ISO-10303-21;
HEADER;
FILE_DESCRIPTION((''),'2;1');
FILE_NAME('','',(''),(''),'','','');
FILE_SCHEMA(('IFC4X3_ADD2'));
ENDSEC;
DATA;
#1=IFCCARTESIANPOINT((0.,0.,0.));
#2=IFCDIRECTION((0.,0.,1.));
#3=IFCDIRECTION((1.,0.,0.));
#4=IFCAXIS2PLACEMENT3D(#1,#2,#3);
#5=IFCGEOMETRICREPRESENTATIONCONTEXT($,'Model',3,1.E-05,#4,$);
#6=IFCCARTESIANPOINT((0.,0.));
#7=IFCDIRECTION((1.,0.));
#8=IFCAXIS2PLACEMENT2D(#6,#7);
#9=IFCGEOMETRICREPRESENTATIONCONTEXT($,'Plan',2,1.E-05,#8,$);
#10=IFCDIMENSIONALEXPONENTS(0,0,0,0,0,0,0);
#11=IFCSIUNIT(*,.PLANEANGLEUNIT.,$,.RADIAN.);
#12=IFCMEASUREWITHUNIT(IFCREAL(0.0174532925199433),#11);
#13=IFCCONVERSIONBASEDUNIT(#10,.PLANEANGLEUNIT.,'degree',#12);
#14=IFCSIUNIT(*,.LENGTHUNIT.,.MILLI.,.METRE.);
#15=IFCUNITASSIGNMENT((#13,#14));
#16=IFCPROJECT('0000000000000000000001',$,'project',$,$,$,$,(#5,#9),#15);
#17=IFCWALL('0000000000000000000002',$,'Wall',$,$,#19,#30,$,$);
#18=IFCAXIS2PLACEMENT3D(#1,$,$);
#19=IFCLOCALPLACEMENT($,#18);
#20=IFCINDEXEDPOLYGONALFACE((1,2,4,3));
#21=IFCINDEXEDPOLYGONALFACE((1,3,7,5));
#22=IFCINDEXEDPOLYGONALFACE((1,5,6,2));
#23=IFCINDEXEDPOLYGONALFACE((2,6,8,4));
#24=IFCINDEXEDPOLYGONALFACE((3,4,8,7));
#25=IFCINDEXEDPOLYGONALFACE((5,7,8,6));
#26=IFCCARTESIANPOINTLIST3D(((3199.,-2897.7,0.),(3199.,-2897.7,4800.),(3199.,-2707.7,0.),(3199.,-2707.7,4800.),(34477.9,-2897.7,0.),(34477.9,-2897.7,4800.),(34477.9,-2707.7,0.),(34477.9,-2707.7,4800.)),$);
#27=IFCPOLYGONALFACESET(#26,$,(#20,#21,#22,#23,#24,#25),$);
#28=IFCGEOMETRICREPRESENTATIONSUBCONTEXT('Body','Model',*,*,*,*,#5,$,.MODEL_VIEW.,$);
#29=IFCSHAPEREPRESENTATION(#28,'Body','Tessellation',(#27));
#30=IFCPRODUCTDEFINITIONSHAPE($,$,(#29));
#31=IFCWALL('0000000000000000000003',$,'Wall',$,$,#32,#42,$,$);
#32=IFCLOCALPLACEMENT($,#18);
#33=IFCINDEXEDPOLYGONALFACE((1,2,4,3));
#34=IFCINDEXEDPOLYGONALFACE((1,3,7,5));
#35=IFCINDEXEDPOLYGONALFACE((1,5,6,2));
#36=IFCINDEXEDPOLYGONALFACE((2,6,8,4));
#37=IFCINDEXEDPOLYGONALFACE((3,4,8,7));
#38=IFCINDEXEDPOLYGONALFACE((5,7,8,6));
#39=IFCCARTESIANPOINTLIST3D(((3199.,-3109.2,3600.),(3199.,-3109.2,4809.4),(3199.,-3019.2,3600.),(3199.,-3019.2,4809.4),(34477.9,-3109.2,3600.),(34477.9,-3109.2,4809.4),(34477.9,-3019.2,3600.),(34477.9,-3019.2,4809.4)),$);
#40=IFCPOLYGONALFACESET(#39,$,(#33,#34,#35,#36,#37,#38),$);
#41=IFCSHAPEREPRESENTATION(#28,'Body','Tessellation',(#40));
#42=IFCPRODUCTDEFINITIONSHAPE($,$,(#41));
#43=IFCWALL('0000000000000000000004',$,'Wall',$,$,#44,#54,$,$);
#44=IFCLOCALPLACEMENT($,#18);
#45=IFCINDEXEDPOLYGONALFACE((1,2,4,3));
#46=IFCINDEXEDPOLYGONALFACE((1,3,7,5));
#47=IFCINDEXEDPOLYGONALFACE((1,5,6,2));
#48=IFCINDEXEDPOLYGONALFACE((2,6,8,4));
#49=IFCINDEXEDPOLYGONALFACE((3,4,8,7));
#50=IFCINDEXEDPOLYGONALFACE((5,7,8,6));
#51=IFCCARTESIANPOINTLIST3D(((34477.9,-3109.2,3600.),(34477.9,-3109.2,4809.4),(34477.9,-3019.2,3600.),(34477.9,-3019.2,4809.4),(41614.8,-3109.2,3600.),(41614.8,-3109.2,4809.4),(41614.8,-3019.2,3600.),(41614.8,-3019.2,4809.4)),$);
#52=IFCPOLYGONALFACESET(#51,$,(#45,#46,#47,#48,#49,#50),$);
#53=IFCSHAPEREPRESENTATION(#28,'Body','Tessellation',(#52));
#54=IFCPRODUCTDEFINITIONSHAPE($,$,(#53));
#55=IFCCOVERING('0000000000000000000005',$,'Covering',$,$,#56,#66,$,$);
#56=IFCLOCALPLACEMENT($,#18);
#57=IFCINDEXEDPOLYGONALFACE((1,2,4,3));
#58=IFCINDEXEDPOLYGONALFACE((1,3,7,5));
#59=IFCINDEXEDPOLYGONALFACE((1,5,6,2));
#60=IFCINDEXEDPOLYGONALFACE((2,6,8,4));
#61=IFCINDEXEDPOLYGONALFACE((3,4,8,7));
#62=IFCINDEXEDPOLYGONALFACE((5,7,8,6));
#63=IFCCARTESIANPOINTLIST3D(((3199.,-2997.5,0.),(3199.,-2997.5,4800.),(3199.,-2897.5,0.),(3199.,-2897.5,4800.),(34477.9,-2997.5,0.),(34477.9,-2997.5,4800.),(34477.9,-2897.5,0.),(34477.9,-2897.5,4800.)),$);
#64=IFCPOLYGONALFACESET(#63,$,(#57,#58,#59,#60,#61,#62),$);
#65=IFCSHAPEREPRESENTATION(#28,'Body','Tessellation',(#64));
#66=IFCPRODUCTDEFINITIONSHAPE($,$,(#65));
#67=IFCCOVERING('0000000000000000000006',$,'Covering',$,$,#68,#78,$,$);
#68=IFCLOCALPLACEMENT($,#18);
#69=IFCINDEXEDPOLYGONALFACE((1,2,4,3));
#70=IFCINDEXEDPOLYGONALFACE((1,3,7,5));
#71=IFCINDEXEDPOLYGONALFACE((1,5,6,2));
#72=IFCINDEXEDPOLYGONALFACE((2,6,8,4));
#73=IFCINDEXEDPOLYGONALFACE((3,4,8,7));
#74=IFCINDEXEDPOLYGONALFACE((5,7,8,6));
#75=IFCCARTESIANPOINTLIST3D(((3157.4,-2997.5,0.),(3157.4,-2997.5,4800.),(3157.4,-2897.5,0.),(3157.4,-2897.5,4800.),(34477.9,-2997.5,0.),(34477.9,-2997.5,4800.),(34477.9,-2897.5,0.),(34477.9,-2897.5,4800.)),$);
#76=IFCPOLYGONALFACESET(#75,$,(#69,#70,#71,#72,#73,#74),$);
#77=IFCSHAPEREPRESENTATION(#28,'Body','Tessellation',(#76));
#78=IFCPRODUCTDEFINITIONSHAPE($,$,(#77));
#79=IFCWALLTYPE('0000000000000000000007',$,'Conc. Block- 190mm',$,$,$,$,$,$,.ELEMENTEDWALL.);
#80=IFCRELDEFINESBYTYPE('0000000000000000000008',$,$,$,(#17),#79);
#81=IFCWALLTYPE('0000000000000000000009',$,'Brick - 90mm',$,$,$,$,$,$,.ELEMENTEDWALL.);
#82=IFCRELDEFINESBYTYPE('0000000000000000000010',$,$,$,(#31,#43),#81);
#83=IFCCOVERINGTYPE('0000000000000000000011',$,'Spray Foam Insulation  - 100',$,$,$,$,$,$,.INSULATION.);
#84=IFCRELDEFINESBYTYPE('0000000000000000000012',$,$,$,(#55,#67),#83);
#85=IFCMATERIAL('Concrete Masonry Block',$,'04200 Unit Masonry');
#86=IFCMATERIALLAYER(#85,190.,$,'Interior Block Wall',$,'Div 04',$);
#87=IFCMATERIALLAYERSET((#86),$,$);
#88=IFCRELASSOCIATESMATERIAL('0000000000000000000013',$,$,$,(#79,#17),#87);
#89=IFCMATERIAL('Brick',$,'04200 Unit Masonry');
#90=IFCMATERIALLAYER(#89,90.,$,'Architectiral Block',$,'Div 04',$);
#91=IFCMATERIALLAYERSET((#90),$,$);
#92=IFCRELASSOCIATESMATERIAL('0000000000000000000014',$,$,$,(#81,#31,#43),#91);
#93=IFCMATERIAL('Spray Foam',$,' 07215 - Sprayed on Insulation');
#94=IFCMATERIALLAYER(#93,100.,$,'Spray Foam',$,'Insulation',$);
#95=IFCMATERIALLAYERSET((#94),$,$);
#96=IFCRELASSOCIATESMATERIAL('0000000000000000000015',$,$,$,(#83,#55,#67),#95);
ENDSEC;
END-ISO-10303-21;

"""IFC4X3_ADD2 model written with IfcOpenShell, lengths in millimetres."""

from ifc_helpers import new_model, entity, si_unit, converted_unit, frame, origin_with_axes, origin_2d_with_axis, place, context, subcontext, project, indexed_curve, outline, extrude, material, layer, layer_set, layer_usage, type_object, element, save


model = new_model("IFC4X3_ADD2")

# Units and contexts
model_context = context("Model", 3, precision=1e-05, world=origin_with_axes())
plan_context = context("Plan", 2, precision=1e-05, world=origin_2d_with_axis())
body_context = subcontext(model_context, "Body", "Model", "MODEL_VIEW")
ifc_project = project(units=[converted_unit("PLANEANGLEUNIT", "degree", entity("IfcReal", 0.0174532925199433), si_unit("PLANEANGLEUNIT", "RADIAN"), dimensions=[0, 0, 0, 0, 0, 0, 0]), si_unit("LENGTHUNIT", "METRE", prefix="MILLI")], contexts=[model_context, plan_context])

# Walls
ifc_material_1 = material(Name="Concrete Masonry Block", Category="04200 Unit Masonry")
ifc_layer_1 = layer(ifc_material_1, 190.0, Name="Interior Block Wall", Category="Div 04")
ifc_layer_set_1 = layer_set([ifc_layer_1])
ifc_layer_usage_1 = layer_usage(ifc_layer_set_1, "AXIS2", "POSITIVE", 0.0)
wall_type_1 = type_object("IfcWallType", Name="Conc. Block- 190mm", PredefinedType="ELEMENTEDWALL", material=ifc_layer_set_1)
wall_1_placement = place(None, frame((34477.9, -2707.7, 0.0), z_axis=(0.0, 0.0, 1.0), x_axis=(-1.0, 0.0, 0.0)))
element("IfcWall", 1, at=wall_1_placement, type_object=wall_type_1, material=ifc_layer_usage_1, Name="Wall", context=body_context, shape_type="SweptSolid", body=[
    extrude(outline(indexed_curve([(0.0, 0.0), (0.0, 190.0), (31278.9, 190.0), (31278.9, 0.0), (0.0, 0.0)], self_intersect=False)), origin_with_axes(), (0.0, 0.0, 1.0), 4800.0),
])
ifc_material_2 = material(Name="Brick", Category="04200 Unit Masonry")
ifc_layer_2 = layer(ifc_material_2, 90.0, Name="Architectiral Block", Category="Div 04")
ifc_layer_set_2 = layer_set([ifc_layer_2])
ifc_layer_usage_2 = layer_usage(ifc_layer_set_2, "AXIS2", "POSITIVE", 0.0)
wall_type_2 = type_object("IfcWallType", Name="Brick - 90mm", PredefinedType="ELEMENTEDWALL", material=ifc_layer_set_2)
wall_2_placement = place(None, frame((3199.0, -3109.2, 3600.0), z_axis=(0.0, 0.0, 1.0), x_axis=(1.0, 0.0, 0.0)))
element("IfcWall", 2, at=wall_2_placement, type_object=wall_type_2, material=ifc_layer_usage_2, Name="Wall", context=body_context, shape_type="SweptSolid", body=[
    extrude(outline(indexed_curve([(0.0, 0.0), (0.0, 90.0), (31278.9, 90.0), (31278.9, 0.0), (0.0, 0.0)], self_intersect=False)), origin_with_axes(), (0.0, 0.0, 1.0), 1209.4),
])
ifc_layer_usage_3 = layer_usage(ifc_layer_set_2, "AXIS2", "POSITIVE", 0.0)
wall_3_placement = place(None, frame((34477.9, -3109.2, 3600.0), z_axis=(0.0, 0.0, 1.0), x_axis=(1.0, 0.0, 0.0)))
element("IfcWall", 3, at=wall_3_placement, type_object=wall_type_2, material=ifc_layer_usage_3, Name="Wall", context=body_context, shape_type="SweptSolid", body=[
    extrude(outline(indexed_curve([(0.0, 0.0), (0.0, 90.0), (7136.9, 90.0), (7136.9, 0.0), (0.0, 0.0)], self_intersect=False)), origin_with_axes(), (0.0, 0.0, 1.0), 1209.4),
])

# Coverings
ifc_material_3 = material(Name="Spray Foam", Category=" 07215 - Sprayed on Insulation")
ifc_layer_3 = layer(ifc_material_3, 100.0, Name="Spray Foam", Category="Insulation")
ifc_layer_set_3 = layer_set([ifc_layer_3])
ifc_layer_usage_4 = layer_usage(ifc_layer_set_3, "AXIS2", "POSITIVE", 0.0)
covering_type = type_object("IfcCoveringType", Name="Spray Foam Insulation  - 100", PredefinedType="INSULATION", material=ifc_layer_set_3)
covering_1_placement = place(None, frame((34477.9, -2897.5, 0.0), z_axis=(0.0, 0.0, 1.0), x_axis=(-1.0, 0.000001, 0.0)))
element("IfcCovering", 4, at=covering_1_placement, type_object=covering_type, material=ifc_layer_usage_4, Name="Covering", context=body_context, shape_type="SweptSolid", body=[
    extrude(outline(indexed_curve([(0.0, 0.0), (0.0, 100.0), (31278.9, 100.0), (31278.9, 0.0), (0.0, 0.0)], self_intersect=False)), origin_with_axes(), (0.0, 0.0, 1.0), 4800.0),
])
ifc_layer_usage_5 = layer_usage(ifc_layer_set_3, "AXIS2", "POSITIVE", 0.0)
covering_2_placement = place(None, frame((34477.9, -2897.5, 0.0), z_axis=(0.0, 0.0, 1.0), x_axis=(-1.0, 0.000001, 0.0)))
element("IfcCovering", 5, at=covering_2_placement, type_object=covering_type, material=ifc_layer_usage_5, Name="Covering", context=body_context, shape_type="SweptSolid", body=[
    extrude(outline(indexed_curve([(0.0, 0.0), (0.0, 100.0), (31320.5, 100.0), (31320.5, 0.0), (0.0, 0.0)], self_intersect=False)), origin_with_axes(), (0.0, 0.0, 1.0), 4800.0),
])

save(model, "model.ifc")
